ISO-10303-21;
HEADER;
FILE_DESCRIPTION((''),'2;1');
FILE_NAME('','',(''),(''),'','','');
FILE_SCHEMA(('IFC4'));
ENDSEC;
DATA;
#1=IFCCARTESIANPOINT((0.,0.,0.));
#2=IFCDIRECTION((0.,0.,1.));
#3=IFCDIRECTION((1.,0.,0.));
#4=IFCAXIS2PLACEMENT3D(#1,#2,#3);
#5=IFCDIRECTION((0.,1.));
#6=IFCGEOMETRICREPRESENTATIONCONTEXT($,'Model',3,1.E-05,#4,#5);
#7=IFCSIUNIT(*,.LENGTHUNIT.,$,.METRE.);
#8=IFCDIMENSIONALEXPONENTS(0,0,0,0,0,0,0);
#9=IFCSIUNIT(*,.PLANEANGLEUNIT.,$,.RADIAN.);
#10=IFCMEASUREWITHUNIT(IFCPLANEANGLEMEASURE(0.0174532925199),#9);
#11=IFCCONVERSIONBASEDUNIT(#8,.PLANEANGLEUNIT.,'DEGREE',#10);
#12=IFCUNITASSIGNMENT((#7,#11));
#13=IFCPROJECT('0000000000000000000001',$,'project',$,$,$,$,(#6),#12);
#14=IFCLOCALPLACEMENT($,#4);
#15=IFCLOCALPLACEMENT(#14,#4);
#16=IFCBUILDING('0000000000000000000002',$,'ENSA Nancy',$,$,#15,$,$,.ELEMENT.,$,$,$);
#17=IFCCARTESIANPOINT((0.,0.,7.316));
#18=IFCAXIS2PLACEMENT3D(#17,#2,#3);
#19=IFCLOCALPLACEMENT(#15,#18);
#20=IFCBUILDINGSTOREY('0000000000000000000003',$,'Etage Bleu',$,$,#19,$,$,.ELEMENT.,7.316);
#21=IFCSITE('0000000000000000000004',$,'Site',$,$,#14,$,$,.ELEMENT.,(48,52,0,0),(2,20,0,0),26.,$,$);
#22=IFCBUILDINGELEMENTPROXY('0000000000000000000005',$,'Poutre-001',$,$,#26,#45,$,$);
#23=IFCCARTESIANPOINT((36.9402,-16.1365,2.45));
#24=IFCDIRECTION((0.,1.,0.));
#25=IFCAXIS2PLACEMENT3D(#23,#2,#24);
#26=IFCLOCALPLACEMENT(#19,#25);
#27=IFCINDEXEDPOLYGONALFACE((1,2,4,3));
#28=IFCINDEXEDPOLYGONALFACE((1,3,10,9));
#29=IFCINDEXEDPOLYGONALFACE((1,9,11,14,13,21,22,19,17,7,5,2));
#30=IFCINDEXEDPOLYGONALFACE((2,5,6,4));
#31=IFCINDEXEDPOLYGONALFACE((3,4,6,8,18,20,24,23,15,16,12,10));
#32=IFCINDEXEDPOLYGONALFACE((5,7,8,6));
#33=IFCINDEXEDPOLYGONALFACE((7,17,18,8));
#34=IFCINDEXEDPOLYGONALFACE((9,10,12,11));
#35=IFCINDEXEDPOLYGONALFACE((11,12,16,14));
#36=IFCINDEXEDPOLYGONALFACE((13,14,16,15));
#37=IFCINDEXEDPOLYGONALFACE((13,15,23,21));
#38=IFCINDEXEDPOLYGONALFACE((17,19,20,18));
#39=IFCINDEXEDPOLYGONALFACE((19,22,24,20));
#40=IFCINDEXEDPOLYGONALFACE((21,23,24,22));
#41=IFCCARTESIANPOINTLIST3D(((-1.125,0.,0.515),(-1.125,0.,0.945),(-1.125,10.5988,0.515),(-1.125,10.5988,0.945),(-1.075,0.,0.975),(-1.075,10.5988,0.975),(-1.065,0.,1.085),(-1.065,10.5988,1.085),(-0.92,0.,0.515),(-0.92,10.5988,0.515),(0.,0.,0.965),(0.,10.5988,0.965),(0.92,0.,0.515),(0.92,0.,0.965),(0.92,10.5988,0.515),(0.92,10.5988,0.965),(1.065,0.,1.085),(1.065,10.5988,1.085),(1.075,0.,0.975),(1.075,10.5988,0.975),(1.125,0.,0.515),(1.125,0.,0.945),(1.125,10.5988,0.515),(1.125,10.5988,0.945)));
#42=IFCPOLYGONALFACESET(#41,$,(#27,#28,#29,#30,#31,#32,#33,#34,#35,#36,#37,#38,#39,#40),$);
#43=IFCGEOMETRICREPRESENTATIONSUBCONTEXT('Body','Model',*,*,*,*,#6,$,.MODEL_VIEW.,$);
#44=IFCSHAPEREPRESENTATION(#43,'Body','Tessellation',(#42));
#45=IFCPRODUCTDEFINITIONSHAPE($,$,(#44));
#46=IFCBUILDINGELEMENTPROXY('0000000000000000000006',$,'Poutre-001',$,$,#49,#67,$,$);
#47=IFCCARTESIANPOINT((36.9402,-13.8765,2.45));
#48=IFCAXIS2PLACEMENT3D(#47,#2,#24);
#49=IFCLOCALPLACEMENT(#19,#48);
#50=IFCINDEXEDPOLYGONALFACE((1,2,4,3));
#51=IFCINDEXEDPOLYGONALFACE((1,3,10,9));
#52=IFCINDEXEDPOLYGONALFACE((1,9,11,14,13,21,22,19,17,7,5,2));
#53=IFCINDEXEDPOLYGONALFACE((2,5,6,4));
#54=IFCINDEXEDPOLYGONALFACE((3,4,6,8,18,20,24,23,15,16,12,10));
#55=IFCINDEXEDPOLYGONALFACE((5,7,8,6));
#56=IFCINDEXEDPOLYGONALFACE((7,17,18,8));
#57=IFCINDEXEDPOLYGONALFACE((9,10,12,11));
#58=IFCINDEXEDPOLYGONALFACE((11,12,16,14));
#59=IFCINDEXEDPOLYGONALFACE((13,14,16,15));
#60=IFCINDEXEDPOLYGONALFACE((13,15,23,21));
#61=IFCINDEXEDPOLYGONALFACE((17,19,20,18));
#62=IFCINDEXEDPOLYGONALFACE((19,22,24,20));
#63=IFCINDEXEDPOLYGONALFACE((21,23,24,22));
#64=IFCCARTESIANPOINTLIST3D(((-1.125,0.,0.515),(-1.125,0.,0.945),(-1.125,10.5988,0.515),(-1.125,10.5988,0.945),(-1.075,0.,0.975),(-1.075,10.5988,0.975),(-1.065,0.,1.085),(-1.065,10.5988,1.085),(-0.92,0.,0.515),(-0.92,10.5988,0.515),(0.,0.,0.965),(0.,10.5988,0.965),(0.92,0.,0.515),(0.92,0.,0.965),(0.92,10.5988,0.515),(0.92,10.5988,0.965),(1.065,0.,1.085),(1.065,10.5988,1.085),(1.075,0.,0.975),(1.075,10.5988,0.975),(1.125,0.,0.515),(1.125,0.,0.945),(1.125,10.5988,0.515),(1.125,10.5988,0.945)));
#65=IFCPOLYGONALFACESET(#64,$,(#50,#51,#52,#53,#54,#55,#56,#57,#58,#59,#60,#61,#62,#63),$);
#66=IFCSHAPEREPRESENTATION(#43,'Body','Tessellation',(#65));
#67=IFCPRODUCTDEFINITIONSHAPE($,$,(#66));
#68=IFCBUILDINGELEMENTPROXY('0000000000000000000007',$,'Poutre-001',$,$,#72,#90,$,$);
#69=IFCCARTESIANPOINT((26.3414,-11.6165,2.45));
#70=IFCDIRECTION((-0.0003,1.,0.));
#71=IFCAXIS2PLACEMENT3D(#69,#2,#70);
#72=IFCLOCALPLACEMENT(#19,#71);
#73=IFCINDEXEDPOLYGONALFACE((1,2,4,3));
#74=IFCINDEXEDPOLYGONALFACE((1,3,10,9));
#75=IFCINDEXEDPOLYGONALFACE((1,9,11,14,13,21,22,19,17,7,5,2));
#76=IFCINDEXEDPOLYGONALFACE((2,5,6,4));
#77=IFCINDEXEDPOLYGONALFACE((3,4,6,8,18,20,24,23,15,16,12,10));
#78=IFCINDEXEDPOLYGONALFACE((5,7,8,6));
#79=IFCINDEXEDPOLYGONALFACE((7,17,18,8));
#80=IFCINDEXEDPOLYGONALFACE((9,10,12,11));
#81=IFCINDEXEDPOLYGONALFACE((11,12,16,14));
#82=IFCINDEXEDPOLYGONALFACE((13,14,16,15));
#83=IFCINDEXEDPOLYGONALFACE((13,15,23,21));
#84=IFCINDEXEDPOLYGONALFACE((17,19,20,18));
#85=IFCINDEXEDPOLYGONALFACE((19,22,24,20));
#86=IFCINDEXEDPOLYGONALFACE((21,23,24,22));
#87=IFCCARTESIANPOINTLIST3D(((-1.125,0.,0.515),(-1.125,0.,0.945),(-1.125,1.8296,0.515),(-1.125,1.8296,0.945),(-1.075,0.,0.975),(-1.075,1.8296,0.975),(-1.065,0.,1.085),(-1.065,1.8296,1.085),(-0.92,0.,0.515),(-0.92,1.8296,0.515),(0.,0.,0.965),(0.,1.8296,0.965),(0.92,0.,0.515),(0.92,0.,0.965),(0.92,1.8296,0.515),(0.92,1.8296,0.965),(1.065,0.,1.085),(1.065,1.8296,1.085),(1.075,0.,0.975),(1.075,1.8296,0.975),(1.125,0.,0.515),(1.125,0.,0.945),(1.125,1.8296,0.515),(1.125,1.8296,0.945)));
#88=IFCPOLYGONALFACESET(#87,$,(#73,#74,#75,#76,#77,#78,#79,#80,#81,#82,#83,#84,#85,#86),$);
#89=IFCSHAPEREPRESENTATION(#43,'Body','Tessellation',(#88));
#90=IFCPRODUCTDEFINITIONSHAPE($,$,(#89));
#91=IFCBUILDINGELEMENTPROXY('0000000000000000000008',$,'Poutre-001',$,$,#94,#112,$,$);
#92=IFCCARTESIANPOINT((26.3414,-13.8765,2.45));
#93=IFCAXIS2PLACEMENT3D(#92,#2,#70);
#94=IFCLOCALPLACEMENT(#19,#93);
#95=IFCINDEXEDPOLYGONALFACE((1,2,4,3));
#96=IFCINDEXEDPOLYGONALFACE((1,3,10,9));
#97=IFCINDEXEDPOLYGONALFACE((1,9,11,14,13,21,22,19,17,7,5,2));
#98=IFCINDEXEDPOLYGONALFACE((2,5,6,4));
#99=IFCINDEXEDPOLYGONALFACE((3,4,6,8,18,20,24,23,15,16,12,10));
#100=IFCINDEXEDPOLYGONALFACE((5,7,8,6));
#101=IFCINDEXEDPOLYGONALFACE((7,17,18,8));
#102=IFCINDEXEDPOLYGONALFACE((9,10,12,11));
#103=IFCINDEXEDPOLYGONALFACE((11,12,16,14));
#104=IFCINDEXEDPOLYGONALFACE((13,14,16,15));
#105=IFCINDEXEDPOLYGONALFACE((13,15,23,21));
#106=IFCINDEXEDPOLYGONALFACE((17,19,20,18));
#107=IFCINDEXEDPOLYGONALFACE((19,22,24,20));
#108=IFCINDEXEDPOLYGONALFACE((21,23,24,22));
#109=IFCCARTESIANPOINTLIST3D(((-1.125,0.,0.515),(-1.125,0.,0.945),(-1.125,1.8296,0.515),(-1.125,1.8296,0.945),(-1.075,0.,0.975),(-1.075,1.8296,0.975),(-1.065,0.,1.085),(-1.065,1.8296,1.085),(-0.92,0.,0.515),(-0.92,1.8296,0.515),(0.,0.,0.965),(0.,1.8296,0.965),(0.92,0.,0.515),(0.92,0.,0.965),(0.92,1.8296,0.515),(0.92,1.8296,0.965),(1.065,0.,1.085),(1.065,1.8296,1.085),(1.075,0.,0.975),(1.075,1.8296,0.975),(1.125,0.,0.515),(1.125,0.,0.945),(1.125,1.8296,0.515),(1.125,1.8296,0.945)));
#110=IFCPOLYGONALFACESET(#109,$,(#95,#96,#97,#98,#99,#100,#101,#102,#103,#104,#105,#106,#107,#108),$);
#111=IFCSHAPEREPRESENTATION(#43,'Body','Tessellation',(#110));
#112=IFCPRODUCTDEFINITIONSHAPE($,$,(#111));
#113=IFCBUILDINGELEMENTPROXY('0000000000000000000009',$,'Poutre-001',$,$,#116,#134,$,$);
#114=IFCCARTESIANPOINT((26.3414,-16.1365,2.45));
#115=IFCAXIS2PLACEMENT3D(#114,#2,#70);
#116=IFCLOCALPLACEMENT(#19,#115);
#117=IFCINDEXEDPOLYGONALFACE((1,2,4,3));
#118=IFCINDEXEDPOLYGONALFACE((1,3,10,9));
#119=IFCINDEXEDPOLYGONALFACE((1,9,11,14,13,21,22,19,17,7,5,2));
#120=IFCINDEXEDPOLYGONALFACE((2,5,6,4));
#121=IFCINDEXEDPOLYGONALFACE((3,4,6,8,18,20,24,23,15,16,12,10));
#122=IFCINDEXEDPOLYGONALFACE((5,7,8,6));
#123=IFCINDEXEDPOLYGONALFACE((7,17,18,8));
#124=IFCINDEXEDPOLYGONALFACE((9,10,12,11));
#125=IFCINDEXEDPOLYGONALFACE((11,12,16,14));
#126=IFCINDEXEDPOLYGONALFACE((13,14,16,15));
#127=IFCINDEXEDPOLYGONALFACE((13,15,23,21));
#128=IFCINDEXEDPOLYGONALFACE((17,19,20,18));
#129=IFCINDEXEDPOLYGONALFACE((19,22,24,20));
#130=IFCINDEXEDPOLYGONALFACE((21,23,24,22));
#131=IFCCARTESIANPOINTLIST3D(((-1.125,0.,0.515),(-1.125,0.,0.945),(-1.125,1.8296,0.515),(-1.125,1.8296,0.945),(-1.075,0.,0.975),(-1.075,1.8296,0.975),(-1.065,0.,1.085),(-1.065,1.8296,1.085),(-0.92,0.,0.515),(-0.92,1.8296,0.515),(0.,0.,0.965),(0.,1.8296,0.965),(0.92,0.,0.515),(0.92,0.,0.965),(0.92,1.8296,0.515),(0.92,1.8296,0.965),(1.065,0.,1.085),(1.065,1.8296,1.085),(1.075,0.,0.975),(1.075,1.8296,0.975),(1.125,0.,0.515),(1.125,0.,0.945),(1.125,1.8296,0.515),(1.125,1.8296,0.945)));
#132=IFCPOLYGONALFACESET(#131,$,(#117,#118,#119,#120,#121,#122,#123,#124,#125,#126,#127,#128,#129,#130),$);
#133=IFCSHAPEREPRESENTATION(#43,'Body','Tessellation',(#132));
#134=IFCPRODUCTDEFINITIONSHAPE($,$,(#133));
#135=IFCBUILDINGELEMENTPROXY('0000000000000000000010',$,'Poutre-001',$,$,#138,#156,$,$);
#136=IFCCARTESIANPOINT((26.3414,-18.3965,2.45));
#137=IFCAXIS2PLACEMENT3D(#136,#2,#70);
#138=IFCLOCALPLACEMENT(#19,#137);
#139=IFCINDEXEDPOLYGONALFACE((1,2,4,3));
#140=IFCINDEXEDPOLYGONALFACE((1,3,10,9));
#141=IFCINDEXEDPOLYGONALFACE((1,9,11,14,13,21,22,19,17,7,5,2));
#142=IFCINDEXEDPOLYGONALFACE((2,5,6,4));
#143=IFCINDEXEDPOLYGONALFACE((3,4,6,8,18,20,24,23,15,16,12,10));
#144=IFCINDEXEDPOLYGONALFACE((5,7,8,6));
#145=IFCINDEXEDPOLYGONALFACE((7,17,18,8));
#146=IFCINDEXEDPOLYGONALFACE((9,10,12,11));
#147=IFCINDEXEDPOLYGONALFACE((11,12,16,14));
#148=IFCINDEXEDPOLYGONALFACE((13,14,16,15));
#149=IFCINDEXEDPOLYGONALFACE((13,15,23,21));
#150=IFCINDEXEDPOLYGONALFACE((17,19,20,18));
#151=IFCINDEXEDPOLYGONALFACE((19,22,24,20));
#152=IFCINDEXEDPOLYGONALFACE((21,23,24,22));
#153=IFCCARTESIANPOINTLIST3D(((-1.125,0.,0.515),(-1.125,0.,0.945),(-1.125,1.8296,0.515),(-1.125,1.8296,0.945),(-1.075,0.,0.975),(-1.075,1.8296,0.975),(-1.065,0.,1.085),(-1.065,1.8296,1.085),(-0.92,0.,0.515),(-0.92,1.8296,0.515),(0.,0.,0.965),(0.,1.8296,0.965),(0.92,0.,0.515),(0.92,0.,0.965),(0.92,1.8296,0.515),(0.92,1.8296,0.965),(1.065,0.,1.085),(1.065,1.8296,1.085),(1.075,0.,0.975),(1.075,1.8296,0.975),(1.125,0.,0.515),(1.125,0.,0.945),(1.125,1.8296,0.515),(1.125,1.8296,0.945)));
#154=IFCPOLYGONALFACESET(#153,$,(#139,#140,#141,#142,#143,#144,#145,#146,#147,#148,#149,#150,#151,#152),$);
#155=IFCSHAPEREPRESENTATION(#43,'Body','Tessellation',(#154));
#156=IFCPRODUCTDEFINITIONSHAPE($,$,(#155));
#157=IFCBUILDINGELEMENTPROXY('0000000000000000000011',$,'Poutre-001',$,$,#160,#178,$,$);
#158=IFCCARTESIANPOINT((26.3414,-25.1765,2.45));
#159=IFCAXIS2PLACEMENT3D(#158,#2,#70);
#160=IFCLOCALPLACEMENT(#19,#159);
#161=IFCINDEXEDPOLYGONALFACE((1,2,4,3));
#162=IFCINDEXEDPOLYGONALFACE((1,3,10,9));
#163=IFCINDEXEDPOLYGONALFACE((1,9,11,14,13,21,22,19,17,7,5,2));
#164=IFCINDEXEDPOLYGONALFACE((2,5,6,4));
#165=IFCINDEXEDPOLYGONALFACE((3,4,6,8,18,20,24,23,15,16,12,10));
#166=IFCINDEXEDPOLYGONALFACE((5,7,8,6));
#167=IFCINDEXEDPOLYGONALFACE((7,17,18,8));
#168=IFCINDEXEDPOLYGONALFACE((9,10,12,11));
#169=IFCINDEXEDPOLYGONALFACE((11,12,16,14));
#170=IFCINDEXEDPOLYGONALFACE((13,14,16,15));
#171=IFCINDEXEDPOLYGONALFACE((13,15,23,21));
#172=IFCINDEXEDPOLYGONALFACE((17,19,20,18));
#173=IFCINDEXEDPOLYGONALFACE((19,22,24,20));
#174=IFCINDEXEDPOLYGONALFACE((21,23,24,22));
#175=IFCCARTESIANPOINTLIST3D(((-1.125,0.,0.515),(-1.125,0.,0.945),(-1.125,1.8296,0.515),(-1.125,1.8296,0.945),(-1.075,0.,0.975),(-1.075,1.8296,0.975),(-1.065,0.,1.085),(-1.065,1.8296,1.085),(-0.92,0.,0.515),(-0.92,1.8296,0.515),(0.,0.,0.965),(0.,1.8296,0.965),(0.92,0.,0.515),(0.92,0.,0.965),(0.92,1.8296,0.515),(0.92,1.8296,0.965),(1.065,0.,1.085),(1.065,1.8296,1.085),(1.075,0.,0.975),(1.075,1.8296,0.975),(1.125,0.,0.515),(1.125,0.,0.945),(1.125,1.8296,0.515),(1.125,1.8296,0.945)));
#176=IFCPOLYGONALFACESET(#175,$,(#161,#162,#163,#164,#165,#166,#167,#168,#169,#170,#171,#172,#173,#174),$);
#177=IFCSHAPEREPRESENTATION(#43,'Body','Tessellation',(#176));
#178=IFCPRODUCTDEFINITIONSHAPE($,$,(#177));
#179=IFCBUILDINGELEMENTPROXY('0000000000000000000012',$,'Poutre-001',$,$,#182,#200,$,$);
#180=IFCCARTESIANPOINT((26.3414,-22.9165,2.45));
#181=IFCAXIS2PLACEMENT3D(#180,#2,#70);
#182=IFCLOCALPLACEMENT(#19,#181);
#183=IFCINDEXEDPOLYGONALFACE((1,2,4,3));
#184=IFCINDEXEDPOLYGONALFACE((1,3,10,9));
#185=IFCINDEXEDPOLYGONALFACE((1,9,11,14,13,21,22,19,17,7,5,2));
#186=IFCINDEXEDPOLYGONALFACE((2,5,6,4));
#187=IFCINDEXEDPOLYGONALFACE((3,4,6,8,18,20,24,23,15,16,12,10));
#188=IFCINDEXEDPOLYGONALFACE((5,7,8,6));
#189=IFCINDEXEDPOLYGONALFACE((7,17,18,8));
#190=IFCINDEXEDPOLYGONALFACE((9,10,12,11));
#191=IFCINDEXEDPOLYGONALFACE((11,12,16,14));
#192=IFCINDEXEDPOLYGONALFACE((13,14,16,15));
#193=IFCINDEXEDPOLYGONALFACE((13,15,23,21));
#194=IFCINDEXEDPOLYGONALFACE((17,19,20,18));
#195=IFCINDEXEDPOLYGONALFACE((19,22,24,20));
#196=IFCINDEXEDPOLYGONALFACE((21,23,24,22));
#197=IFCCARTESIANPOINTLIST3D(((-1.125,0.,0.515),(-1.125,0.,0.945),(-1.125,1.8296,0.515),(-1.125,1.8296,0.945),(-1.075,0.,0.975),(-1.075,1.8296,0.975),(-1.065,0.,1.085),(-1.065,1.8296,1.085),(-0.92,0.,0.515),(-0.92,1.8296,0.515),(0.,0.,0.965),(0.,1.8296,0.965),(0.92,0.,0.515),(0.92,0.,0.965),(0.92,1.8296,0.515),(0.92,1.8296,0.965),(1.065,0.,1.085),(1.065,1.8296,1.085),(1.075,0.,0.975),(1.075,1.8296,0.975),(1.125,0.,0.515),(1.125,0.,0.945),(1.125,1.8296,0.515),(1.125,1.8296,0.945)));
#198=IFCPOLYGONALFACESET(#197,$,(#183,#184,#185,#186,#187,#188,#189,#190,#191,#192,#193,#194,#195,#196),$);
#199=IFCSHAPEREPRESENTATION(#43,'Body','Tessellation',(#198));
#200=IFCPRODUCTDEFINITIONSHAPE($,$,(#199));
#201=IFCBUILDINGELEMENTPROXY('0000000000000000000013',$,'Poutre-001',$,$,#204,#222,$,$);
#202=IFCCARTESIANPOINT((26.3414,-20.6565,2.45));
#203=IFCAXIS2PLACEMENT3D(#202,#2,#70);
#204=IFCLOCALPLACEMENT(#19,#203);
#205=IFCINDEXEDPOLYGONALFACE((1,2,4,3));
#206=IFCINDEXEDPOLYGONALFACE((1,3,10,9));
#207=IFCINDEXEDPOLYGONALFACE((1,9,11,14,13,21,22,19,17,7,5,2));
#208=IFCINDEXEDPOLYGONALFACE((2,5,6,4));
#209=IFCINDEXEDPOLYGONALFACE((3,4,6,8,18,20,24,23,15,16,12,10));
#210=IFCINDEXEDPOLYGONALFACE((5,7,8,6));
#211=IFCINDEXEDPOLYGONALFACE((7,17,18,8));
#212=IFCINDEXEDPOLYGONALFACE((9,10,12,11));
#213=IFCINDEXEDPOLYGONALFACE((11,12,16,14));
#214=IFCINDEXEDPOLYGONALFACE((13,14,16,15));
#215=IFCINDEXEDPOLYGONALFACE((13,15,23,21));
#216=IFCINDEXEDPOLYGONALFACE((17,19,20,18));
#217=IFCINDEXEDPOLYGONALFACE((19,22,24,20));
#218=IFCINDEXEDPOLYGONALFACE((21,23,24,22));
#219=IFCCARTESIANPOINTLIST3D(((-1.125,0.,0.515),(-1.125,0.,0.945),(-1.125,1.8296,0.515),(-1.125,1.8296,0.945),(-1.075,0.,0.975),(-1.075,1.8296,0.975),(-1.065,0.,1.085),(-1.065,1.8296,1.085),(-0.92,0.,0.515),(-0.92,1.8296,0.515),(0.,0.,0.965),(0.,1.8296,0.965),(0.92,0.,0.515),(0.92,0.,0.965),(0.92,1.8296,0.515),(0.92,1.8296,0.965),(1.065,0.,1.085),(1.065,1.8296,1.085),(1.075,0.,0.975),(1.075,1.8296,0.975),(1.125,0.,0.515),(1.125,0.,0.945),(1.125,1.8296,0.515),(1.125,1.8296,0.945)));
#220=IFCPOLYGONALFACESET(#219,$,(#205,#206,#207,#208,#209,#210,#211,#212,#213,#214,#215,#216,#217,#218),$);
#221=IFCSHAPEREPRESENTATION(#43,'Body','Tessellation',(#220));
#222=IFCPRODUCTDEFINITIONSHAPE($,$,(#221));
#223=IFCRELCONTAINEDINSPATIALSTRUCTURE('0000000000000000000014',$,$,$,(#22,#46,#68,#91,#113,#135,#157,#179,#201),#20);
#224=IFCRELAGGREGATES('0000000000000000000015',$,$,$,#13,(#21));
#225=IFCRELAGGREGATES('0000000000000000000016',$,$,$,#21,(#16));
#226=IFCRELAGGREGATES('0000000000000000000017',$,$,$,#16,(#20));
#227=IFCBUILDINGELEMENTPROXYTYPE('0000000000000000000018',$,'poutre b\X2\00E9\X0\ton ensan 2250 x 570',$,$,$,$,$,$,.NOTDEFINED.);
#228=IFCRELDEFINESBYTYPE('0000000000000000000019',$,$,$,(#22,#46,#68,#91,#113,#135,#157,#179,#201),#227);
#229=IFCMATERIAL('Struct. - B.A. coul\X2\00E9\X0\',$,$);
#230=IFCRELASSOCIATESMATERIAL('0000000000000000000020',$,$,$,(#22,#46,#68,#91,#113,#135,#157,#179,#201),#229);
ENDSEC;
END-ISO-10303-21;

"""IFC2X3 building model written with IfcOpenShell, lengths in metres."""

from ifc_helpers import new_model, entity, si_unit, converted_unit, direction, frame, origin_with_axes, place, context, subcontext, project, spatial, polyline, outline, extrude, material, type_object, element, save


model = new_model("IFC2X3")

# Units and contexts
model_context = context("Model", 3, precision=1e-05, world=origin_with_axes(), true_north=direction((0.0, 1.0)))
body_context = subcontext(model_context, "Body", "Model", "MODEL_VIEW")
ifc_project = project(units=[si_unit("LENGTHUNIT", "METRE"), converted_unit("PLANEANGLEUNIT", "DEGREE", entity("IfcPlaneAngleMeasure", 0.0174532925199), si_unit("PLANEANGLEUNIT", "RADIAN"), dimensions=[0, 0, 0, 0, 0, 0, 0])], contexts=[model_context])

# Site, building, storey
site_placement = place(None, origin_with_axes())
site = spatial("IfcSite", under=ifc_project, at=site_placement, Name="Site", CompositionType="ELEMENT", RefLatitude=(48, 52, 0, 0), RefLongitude=(2, 20, 0, 0), RefElevation=26.0)
building_placement = place(site_placement, origin_with_axes())
building = spatial("IfcBuilding", under=site, at=building_placement, Name="ENSA Nancy", CompositionType="ELEMENT")
storey_placement = place(building_placement, frame((0.0, 0.0, 7.316), z_axis=(0.0, 0.0, 1.0), x_axis=(1.0, 0.0, 0.0)))
storey = spatial("IfcBuildingStorey", under=building, at=storey_placement, Name="Etage Bleu", CompositionType="ELEMENT", Elevation=7.316)

# Building element proxies
ifc_material_1 = material(Name="Struct. - B.A. coulé")
building_element_proxy_type_1 = type_object("IfcBuildingElementProxyType", Name="poutre béton ensan 2250 x 570", PredefinedType="NOTDEFINED")
for number, where, z_axis, x_axis, name in (
    (1, (36.9402, -16.1365, 2.45), (0.0, 0.0, 1.0), (0.0, 1.0, 0.0), "Poutre-001"),
    (2, (36.9402, -13.8765, 2.45), (0.0, 0.0, 1.0), (0.0, 1.0, 0.0), "Poutre-001"),
):
    element("IfcBuildingElementProxy", number, at=place(storey_placement, frame(where, z_axis=z_axis, x_axis=x_axis)), inside=storey, type_object=building_element_proxy_type_1, material=ifc_material_1, Name=name, context=body_context, shape_type="SweptSolid", body=[
        extrude(outline(polyline([(-1.065, 1.085), (-1.075, 0.975), (-1.125, 0.945), (-1.125, 0.515), (-0.92, 0.515), (0.0, 0.965), (0.92, 0.965), (0.92, 0.515), (1.125, 0.515), (1.125, 0.945), (1.075, 0.975), (1.065, 1.085), (-1.065, 1.085)])), frame((0.0, 10.5988, 0.0), z_axis=(0.0, -1.0, 0.0), x_axis=(1.0, 0.0, 0.0)), (0.0, 0.0, 1.0), 10.5988),
    ])
for number, where, z_axis, x_axis, name in (
    (3, (26.3414, -11.6165, 2.45), (0.0, 0.0, 1.0), (-0.0003, 1.0, 0.0), "Poutre-001"),
    (4, (26.3414, -13.8765, 2.45), (0.0, 0.0, 1.0), (-0.0003, 1.0, 0.0), "Poutre-001"),
    (5, (26.3414, -16.1365, 2.45), (0.0, 0.0, 1.0), (-0.0003, 1.0, 0.0), "Poutre-001"),
    (6, (26.3414, -18.3965, 2.45), (0.0, 0.0, 1.0), (-0.0003, 1.0, 0.0), "Poutre-001"),
    (7, (26.3414, -25.1765, 2.45), (0.0, 0.0, 1.0), (-0.0003, 1.0, 0.0), "Poutre-001"),
    (8, (26.3414, -22.9165, 2.45), (0.0, 0.0, 1.0), (-0.0003, 1.0, 0.0), "Poutre-001"),
    (9, (26.3414, -20.6565, 2.45), (0.0, 0.0, 1.0), (-0.0003, 1.0, 0.0), "Poutre-001"),
):
    element("IfcBuildingElementProxy", number, at=place(storey_placement, frame(where, z_axis=z_axis, x_axis=x_axis)), inside=storey, type_object=building_element_proxy_type_1, material=ifc_material_1, Name=name, context=body_context, shape_type="SweptSolid", body=[
        extrude(outline(polyline([(-1.065, 1.085), (-1.075, 0.975), (-1.125, 0.945), (-1.125, 0.515), (-0.92, 0.515), (0.0, 0.965), (0.92, 0.965), (0.92, 0.515), (1.125, 0.515), (1.125, 0.945), (1.075, 0.975), (1.065, 1.085), (-1.065, 1.085)])), frame((0.0, 1.8296, 0.0), z_axis=(0.0, -1.0, 0.0), x_axis=(1.0, 0.0, 0.0)), (0.0, 0.0, 1.0), 1.8296),
    ])

save(model, "model.ifc")
